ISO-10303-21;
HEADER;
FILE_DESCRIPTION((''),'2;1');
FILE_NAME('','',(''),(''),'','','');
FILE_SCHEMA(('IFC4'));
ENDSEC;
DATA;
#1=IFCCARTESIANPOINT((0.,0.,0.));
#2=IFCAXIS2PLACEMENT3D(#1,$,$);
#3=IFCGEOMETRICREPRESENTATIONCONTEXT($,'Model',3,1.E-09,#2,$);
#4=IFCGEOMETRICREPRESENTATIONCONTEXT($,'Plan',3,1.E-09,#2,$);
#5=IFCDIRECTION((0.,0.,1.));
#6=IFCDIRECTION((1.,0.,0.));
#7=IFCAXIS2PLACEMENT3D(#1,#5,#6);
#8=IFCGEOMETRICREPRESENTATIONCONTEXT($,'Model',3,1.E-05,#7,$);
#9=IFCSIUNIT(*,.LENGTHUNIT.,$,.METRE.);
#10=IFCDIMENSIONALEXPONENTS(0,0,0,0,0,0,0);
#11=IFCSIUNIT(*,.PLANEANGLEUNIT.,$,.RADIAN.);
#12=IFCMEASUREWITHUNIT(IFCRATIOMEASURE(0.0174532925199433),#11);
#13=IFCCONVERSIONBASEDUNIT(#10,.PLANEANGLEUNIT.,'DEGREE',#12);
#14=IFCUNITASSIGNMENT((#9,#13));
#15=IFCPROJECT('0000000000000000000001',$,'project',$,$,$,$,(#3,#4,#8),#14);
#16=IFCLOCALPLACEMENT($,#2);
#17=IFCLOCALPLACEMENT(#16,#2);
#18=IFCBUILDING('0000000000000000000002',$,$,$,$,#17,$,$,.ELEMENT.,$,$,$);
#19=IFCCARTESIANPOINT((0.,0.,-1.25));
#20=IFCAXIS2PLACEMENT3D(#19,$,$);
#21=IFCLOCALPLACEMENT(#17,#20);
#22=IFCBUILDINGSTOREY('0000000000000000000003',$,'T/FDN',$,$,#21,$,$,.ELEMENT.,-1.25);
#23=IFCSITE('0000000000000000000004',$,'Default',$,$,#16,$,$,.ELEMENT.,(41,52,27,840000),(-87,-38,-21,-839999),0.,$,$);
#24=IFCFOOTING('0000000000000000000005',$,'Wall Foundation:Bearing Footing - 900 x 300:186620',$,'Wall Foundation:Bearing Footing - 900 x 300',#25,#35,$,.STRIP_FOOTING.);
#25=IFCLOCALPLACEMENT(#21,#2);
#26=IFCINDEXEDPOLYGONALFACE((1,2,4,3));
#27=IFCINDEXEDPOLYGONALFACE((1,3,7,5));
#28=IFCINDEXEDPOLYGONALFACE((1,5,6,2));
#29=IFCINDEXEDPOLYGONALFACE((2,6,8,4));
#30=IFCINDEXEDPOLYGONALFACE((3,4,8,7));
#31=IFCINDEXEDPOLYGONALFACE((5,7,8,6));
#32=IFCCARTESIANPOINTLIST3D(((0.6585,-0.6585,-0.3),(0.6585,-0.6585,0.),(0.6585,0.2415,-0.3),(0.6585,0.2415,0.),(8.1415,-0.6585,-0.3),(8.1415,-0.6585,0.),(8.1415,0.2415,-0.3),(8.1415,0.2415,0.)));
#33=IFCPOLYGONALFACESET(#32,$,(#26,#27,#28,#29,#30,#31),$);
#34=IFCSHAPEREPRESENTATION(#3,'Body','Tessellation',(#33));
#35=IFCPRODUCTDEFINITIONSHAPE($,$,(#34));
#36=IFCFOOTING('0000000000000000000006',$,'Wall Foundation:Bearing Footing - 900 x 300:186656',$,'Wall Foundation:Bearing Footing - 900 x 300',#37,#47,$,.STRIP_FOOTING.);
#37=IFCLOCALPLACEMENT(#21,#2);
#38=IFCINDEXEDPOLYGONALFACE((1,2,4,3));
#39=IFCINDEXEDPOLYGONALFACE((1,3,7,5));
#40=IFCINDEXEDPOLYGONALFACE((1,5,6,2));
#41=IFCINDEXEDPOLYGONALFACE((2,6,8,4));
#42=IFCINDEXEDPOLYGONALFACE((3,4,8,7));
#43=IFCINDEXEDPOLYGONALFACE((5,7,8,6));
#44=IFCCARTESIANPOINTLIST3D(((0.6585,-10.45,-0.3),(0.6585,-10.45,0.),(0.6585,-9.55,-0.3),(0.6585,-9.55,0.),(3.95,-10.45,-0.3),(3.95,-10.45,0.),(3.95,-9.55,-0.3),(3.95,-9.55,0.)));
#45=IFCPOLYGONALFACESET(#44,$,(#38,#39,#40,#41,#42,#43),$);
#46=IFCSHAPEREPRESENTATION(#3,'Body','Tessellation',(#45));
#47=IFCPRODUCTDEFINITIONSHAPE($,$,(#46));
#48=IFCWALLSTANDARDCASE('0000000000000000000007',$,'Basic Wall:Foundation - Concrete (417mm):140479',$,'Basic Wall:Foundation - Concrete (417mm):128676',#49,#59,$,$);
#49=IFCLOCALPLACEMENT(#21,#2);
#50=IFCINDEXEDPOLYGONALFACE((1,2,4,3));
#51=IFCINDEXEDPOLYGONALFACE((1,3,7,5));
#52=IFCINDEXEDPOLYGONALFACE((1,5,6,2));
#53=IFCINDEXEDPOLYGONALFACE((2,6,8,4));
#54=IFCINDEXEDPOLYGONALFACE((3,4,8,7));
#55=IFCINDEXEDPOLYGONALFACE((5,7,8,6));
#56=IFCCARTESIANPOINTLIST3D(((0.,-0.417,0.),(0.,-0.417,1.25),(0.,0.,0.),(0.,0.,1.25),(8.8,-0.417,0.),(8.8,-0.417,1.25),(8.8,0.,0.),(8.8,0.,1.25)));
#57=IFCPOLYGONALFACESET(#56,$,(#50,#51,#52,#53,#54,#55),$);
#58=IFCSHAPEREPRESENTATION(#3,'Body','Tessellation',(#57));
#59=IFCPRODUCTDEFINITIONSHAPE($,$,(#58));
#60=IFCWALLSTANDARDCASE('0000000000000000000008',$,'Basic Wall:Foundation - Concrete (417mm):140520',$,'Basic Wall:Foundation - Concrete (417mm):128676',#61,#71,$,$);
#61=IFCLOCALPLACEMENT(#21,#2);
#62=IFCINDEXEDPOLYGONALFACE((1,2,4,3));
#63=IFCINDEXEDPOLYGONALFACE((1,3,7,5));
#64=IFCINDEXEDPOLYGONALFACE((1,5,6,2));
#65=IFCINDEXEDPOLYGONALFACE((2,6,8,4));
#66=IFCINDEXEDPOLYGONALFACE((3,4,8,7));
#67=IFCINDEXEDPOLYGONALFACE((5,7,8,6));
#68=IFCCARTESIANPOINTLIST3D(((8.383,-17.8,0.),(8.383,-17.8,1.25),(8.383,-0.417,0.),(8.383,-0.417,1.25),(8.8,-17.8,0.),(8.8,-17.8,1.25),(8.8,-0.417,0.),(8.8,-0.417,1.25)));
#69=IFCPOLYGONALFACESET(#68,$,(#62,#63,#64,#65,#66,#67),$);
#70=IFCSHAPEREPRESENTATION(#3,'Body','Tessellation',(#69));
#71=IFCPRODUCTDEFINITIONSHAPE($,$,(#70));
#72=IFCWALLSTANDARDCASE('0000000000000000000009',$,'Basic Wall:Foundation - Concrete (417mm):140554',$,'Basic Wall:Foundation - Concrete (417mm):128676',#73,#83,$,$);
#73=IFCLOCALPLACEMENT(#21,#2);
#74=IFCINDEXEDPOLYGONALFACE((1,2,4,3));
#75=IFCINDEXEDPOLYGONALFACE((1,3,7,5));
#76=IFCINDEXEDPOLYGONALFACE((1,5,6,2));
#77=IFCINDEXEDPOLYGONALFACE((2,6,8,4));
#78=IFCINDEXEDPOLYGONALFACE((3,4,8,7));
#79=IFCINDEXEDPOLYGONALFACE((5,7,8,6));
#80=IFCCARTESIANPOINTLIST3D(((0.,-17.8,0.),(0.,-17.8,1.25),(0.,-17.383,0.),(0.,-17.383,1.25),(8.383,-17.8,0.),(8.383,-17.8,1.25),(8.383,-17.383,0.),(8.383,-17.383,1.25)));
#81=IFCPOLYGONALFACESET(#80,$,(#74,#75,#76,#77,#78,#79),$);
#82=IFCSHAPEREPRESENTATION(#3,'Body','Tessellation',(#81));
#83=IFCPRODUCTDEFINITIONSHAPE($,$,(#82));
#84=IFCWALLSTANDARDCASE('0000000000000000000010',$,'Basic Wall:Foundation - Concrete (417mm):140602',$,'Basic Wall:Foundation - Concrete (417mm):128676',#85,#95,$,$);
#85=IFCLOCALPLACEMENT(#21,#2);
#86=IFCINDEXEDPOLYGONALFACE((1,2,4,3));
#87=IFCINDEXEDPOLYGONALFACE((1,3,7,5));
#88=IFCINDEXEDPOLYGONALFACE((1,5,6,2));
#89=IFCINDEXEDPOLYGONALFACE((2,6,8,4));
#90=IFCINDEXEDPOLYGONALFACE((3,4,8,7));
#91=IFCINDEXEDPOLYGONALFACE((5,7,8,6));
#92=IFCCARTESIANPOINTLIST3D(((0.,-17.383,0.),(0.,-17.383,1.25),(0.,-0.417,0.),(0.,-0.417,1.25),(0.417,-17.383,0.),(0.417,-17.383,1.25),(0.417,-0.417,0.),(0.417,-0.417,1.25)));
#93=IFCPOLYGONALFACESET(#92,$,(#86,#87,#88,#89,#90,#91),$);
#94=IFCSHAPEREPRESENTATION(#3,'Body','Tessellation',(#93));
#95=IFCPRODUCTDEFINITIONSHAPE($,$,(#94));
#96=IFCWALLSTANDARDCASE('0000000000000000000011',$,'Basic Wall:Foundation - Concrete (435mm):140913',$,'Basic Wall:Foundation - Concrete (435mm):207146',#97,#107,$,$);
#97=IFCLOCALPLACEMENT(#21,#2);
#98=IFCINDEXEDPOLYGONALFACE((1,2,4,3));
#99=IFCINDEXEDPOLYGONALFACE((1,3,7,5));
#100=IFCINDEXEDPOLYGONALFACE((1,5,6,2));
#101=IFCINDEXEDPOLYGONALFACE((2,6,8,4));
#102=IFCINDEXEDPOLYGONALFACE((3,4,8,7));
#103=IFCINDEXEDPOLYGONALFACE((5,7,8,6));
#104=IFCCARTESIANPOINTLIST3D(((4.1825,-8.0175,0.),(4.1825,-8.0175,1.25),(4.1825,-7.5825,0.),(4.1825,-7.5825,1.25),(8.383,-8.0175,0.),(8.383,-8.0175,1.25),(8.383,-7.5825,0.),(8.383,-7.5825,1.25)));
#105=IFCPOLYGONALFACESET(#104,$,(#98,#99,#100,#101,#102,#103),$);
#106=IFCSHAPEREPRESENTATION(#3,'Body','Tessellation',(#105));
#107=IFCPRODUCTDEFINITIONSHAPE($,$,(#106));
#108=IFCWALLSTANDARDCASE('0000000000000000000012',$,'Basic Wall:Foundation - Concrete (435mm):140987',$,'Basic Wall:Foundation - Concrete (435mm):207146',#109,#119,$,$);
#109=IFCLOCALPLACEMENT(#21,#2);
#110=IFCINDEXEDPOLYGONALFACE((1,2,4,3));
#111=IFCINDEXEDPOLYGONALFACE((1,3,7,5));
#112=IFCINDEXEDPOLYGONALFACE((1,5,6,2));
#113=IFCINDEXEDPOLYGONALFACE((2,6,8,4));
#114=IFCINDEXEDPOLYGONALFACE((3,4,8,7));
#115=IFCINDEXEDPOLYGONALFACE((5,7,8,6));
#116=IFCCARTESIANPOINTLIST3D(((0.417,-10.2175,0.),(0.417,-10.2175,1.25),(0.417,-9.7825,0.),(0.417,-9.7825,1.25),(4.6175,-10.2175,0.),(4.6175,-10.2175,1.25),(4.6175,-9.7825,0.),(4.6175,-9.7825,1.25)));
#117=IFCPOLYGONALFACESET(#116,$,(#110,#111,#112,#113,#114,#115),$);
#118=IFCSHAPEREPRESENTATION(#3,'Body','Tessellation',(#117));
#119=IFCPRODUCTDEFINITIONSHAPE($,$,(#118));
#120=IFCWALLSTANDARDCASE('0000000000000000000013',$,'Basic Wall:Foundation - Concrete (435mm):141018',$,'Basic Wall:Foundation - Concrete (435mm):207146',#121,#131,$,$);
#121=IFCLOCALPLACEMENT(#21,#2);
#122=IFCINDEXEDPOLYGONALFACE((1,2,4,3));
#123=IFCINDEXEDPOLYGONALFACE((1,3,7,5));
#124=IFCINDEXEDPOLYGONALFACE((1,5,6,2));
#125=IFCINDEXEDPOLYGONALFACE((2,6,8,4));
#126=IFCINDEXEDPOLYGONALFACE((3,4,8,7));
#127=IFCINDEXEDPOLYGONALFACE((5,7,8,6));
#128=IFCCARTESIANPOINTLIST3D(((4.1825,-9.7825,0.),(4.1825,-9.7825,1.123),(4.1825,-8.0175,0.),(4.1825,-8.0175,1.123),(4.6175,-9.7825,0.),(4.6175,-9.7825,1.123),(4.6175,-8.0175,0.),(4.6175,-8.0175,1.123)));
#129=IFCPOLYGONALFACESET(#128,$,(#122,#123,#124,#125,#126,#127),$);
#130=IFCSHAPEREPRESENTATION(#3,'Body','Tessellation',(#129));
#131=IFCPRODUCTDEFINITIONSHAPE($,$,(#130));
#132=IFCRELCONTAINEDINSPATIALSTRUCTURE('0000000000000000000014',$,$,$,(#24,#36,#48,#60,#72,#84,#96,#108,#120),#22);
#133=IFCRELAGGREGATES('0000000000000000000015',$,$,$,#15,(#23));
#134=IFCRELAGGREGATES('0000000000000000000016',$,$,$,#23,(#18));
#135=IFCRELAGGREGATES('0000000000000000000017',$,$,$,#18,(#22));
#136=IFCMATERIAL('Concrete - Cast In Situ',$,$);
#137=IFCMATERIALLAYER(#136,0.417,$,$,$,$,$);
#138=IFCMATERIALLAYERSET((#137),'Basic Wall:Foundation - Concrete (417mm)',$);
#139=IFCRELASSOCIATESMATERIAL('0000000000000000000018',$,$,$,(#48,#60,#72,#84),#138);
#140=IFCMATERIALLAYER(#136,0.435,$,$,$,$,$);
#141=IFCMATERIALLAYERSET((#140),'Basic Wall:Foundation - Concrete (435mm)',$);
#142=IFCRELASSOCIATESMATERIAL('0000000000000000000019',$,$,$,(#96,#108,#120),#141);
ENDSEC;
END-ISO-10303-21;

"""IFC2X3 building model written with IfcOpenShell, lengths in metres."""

from ifc_helpers import new_model, entity, si_unit, converted_unit, frame, frame_2d, origin, origin_with_axes, origin_2d_with_axis, place, context, project, spatial, rectangle, extrude, material, layer, layer_set, layer_usage, element, save


model = new_model("IFC2X3")

# Units and contexts
model_context_1 = context("Model", 3, precision=1e-09, world=origin())
plan_context = context("Plan", 3, precision=1e-09, world=origin())
model_context_2 = context("Model", 3, precision=1e-05, world=origin_with_axes())
ifc_project = project(units=[si_unit("LENGTHUNIT", "METRE"), converted_unit("PLANEANGLEUNIT", "DEGREE", entity("IfcRatioMeasure", 0.0174532925199433), si_unit("PLANEANGLEUNIT", "RADIAN"), dimensions=[0, 0, 0, 0, 0, 0, 0])], contexts=[model_context_1, plan_context, model_context_2])

# Site, building, storey
site_placement = place(None, origin())
site = spatial("IfcSite", under=ifc_project, at=site_placement, Name="Default", CompositionType="ELEMENT", RefLatitude=(41, 52, 27, 840000), RefLongitude=(-87, -38, -21, -839999), RefElevation=0.0)
building_placement = place(site_placement, origin())
building = spatial("IfcBuilding", under=site, at=building_placement, CompositionType="ELEMENT")
storey_placement = place(building_placement, frame((0.0, 0.0, -1.25)))
storey = spatial("IfcBuildingStorey", under=building, at=storey_placement, Name="T/FDN", CompositionType="ELEMENT", Elevation=-1.25)

# Footings
footing_1_placement = place(storey_placement, origin())
element("IfcFooting", 1, at=footing_1_placement, inside=storey, Name="Wall Foundation:Bearing Footing - 900 x 300:186620", ObjectType="Wall Foundation:Bearing Footing - 900 x 300", PredefinedType="STRIP_FOOTING", context=model_context_1, shape_type="SweptSolid", body=[
    extrude(rectangle(XDim=7.483, YDim=0.9, at=origin_2d_with_axis()), frame((4.4, -0.2085, -0.3), z_axis=(0.0, 0.0, 1.0), x_axis=(-1.0, 0.0, 0.0)), (0.0, 0.0, 1.0), 0.3),
])
footing_2_placement = place(storey_placement, origin())
element("IfcFooting", 2, at=footing_2_placement, inside=storey, Name="Wall Foundation:Bearing Footing - 900 x 300:186656", ObjectType="Wall Foundation:Bearing Footing - 900 x 300", PredefinedType="STRIP_FOOTING", context=model_context_1, shape_type="SweptSolid", body=[
    extrude(rectangle(XDim=3.2915, YDim=0.9, at=origin_2d_with_axis()), frame((2.3043, -10.0, -0.3)), (0.0, 0.0, 1.0), 0.3),
])

# Walls
ifc_material = material(Name="Concrete - Cast In Situ")
ifc_layer_1 = layer(ifc_material, 0.417)
ifc_layer_set_1 = layer_set([ifc_layer_1], Name="Basic Wall:Foundation - Concrete (417mm)")
ifc_layer_usage_1 = layer_usage(ifc_layer_set_1, "AXIS2", "NEGATIVE", 0.2085)
wall_1_placement = place(storey_placement, frame((0.0, -0.2085, 0.0)))
element("IfcWallStandardCase", 3, at=wall_1_placement, inside=storey, material=ifc_layer_usage_1, Name="Basic Wall:Foundation - Concrete (417mm):140479", ObjectType="Basic Wall:Foundation - Concrete (417mm):128676", context=model_context_1, shape_type="SweptSolid", body=[
    extrude(rectangle(XDim=8.8, YDim=0.417, at=frame_2d((4.4, 0.0), x_axis=(-1.0, 0.0))), origin(), (0.0, 0.0, 1.0), 1.25),
])
ifc_layer_usage_2 = layer_usage(ifc_layer_set_1, "AXIS2", "NEGATIVE", 0.2085)
wall_2_placement = place(storey_placement, frame((8.5915, -0.417, 0.0), z_axis=(0.0, 0.0, 1.0), x_axis=(0.0, -1.0, 0.0)))
element("IfcWallStandardCase", 4, at=wall_2_placement, inside=storey, material=ifc_layer_usage_2, Name="Basic Wall:Foundation - Concrete (417mm):140520", ObjectType="Basic Wall:Foundation - Concrete (417mm):128676", context=model_context_1, shape_type="SweptSolid", body=[
    extrude(rectangle(XDim=17.383, YDim=0.417, at=frame_2d((8.6915, 0.0), x_axis=(-1.0, 0.0))), origin(), (0.0, 0.0, 1.0), 1.25),
])
ifc_layer_usage_3 = layer_usage(ifc_layer_set_1, "AXIS2", "NEGATIVE", 0.2085)
wall_3_placement = place(storey_placement, frame((8.383, -17.5915, 0.0), z_axis=(0.0, 0.0, 1.0), x_axis=(-1.0, 0.0, 0.0)))
element("IfcWallStandardCase", 5, at=wall_3_placement, inside=storey, material=ifc_layer_usage_3, Name="Basic Wall:Foundation - Concrete (417mm):140554", ObjectType="Basic Wall:Foundation - Concrete (417mm):128676", context=model_context_1, shape_type="SweptSolid", body=[
    extrude(rectangle(XDim=8.383, YDim=0.417, at=frame_2d((4.1915, 0.0), x_axis=(-1.0, 0.0))), origin(), (0.0, 0.0, 1.0), 1.25),
])
ifc_layer_usage_4 = layer_usage(ifc_layer_set_1, "AXIS2", "NEGATIVE", 0.2085)
wall_4_placement = place(storey_placement, frame((0.2085, -17.383, 0.0), z_axis=(0.0, 0.0, 1.0), x_axis=(0.0, 1.0, 0.0)))
element("IfcWallStandardCase", 6, at=wall_4_placement, inside=storey, material=ifc_layer_usage_4, Name="Basic Wall:Foundation - Concrete (417mm):140602", ObjectType="Basic Wall:Foundation - Concrete (417mm):128676", context=model_context_1, shape_type="SweptSolid", body=[
    extrude(rectangle(XDim=16.966, YDim=0.417, at=frame_2d((8.483, 0.0), x_axis=(-1.0, 0.0))), origin(), (0.0, 0.0, 1.0), 1.25),
])
ifc_layer_2 = layer(ifc_material, 0.435)
ifc_layer_set_2 = layer_set([ifc_layer_2], Name="Basic Wall:Foundation - Concrete (435mm)")
ifc_layer_usage_5 = layer_usage(ifc_layer_set_2, "AXIS2", "NEGATIVE", 0.2175)
wall_5_placement = place(storey_placement, frame((8.383, -7.8, 0.0), z_axis=(0.0, 0.0, 1.0), x_axis=(-1.0, 0.0, 0.0)))
element("IfcWallStandardCase", 7, at=wall_5_placement, inside=storey, material=ifc_layer_usage_5, Name="Basic Wall:Foundation - Concrete (435mm):140913", ObjectType="Basic Wall:Foundation - Concrete (435mm):207146", context=model_context_1, shape_type="SweptSolid", body=[
    extrude(rectangle(XDim=4.2005, YDim=0.435, at=frame_2d((2.1002, 0.0), x_axis=(-1.0, 0.0))), origin(), (0.0, 0.0, 1.0), 1.25),
])
ifc_layer_usage_6 = layer_usage(ifc_layer_set_2, "AXIS2", "NEGATIVE", 0.2175)
wall_6_placement = place(storey_placement, frame((0.417, -10.0, 0.0)))
element("IfcWallStandardCase", 8, at=wall_6_placement, inside=storey, material=ifc_layer_usage_6, Name="Basic Wall:Foundation - Concrete (435mm):140987", ObjectType="Basic Wall:Foundation - Concrete (435mm):207146", context=model_context_1, shape_type="SweptSolid", body=[
    extrude(rectangle(XDim=4.2005, YDim=0.435, at=frame_2d((2.1002, 0.0), x_axis=(-1.0, 0.0))), origin(), (0.0, 0.0, 1.0), 1.25),
])
ifc_layer_usage_7 = layer_usage(ifc_layer_set_2, "AXIS2", "NEGATIVE", 0.2175)
wall_7_placement = place(storey_placement, frame((4.4, -9.7825, 0.0), z_axis=(0.0, 0.0, 1.0), x_axis=(0.0, 1.0, 0.0)))
element("IfcWallStandardCase", 9, at=wall_7_placement, inside=storey, material=ifc_layer_usage_7, Name="Basic Wall:Foundation - Concrete (435mm):141018", ObjectType="Basic Wall:Foundation - Concrete (435mm):207146", context=model_context_1, shape_type="SweptSolid", body=[
    extrude(rectangle(XDim=1.765, YDim=0.435, at=frame_2d((0.8825, 0.0), x_axis=(-1.0, 0.0))), origin(), (0.0, 0.0, 1.0), 1.123),
])

save(model, "model.ifc")
